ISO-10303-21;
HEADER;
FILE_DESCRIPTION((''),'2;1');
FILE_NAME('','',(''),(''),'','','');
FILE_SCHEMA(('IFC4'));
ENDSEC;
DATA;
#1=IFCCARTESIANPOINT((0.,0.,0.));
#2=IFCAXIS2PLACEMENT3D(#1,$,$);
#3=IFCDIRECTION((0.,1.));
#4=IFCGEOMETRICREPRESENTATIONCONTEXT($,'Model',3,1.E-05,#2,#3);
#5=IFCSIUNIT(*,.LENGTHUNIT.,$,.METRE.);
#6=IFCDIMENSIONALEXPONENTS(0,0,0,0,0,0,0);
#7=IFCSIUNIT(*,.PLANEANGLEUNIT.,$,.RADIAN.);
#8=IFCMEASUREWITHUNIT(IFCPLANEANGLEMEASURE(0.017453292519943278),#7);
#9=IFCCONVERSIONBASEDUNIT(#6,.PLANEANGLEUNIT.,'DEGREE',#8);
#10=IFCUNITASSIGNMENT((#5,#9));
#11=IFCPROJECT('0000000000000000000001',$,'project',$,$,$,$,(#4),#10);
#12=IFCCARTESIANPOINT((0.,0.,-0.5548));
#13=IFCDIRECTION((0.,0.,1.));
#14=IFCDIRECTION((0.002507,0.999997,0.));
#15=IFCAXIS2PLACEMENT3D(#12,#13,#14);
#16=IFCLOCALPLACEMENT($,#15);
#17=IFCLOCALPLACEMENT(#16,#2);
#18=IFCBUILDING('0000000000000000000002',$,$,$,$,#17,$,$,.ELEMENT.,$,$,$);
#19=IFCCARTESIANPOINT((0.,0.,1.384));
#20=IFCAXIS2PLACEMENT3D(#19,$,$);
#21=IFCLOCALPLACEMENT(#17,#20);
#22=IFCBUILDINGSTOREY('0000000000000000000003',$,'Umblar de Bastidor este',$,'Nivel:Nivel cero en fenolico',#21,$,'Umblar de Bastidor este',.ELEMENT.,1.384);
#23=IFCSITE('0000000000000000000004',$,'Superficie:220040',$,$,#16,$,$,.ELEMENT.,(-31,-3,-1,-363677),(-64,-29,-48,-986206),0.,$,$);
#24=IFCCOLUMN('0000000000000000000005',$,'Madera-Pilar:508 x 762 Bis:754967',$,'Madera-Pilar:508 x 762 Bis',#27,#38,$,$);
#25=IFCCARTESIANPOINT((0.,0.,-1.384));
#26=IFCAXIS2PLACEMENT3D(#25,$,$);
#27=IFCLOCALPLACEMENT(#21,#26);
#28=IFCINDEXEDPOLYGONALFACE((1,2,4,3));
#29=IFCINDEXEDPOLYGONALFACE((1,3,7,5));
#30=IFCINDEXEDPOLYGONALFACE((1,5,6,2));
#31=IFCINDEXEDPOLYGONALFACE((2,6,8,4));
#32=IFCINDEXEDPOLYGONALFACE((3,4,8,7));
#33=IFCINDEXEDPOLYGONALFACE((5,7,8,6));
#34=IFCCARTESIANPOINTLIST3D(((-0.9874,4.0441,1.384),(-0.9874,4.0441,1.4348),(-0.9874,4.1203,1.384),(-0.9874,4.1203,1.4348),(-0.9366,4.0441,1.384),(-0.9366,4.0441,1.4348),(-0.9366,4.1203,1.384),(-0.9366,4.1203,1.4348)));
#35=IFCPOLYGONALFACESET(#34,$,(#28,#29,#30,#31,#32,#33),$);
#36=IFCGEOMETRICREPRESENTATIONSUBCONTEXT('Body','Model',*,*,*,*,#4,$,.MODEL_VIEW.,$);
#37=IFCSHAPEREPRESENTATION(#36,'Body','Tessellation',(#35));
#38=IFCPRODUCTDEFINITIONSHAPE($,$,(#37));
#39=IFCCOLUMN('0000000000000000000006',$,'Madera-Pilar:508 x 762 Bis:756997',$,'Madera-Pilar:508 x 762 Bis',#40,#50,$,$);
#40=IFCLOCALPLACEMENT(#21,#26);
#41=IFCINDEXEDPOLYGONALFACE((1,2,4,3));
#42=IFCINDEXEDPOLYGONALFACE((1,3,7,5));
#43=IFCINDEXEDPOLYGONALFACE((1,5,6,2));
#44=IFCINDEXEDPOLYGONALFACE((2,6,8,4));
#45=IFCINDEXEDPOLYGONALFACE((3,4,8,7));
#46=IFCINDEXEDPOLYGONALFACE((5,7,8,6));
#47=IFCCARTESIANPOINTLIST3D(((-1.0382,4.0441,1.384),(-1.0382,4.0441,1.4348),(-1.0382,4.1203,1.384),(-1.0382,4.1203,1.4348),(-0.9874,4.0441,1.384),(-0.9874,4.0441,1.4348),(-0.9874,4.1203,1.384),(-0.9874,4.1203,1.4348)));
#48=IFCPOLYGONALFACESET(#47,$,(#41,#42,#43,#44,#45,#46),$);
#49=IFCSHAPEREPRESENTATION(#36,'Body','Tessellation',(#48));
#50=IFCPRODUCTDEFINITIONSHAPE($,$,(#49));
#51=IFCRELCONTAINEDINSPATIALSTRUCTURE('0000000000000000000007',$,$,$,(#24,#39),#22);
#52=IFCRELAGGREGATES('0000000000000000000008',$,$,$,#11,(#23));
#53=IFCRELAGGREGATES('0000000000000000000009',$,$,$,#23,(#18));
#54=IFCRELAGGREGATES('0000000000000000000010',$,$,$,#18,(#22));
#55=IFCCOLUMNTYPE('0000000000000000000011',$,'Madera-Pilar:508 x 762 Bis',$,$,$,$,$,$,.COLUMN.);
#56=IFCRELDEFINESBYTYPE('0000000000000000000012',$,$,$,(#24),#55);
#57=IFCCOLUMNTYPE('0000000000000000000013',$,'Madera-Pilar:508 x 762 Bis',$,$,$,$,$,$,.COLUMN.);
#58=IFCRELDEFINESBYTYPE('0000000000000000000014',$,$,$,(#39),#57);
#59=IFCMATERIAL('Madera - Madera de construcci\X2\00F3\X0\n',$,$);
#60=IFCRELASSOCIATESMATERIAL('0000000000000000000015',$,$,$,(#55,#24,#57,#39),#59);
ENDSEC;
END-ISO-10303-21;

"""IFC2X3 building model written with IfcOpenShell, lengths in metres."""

from ifc_helpers import new_model, entity, si_unit, converted_unit, direction, frame, frame_2d, origin, place, context, subcontext, project, spatial, rectangle, extrude, source, transform, mapped, material, type_object, type_shapes, element, save


model = new_model("IFC2X3")

# Units and contexts
model_context = context("Model", 3, precision=1e-05, world=origin(), true_north=direction((0.0, 1.0)))
body_context = subcontext(model_context, "Body", "Model", "MODEL_VIEW")
ifc_project = project(units=[si_unit("LENGTHUNIT", "METRE"), converted_unit("PLANEANGLEUNIT", "DEGREE", entity("IfcPlaneAngleMeasure", 0.017453292519943278), si_unit("PLANEANGLEUNIT", "RADIAN"), dimensions=[0, 0, 0, 0, 0, 0, 0])], contexts=[model_context])

# Site, building, storey
site_placement = place(None, frame((0.0, 0.0, -0.5548), z_axis=(0.0, 0.0, 1.0), x_axis=(0.002507, 0.999997, 0.0)))
site = spatial("IfcSite", under=ifc_project, at=site_placement, Name="Superficie:220040", CompositionType="ELEMENT", RefLatitude=(-31, -3, -1, -363677), RefLongitude=(-64, -29, -48, -986206), RefElevation=0.0)
building_placement = place(site_placement, origin())
building = spatial("IfcBuilding", under=site, at=building_placement, CompositionType="ELEMENT")
storey_placement = place(building_placement, frame((0.0, 0.0, 1.384)))
storey = spatial("IfcBuildingStorey", under=building, at=storey_placement, Name="Umblar de Bastidor este", ObjectType="Nivel:Nivel cero en fenolico", LongName="Umblar de Bastidor este", CompositionType="ELEMENT", Elevation=1.384)

# Columns
ifc_material_1 = material(Name="Madera - Madera de construcción")
column_type_1 = type_object("IfcColumnType", Name="Madera-Pilar:508 x 762 Bis", PredefinedType="COLUMN", material=ifc_material_1)
shared_shape_1 = source(origin(), body_context, "Body", "SweptSolid", [
    extrude(rectangle(XDim=0.0508, YDim=0.0762, at=frame_2d((0.0, 0.0), x_axis=(1.0, 0.0))), frame((-0.962, 4.0822, 1.384), z_axis=(0.0, 0.0, 1.0), x_axis=(-1.0, 0.0, 0.0)), (0.0, 0.0, 1.0), 0.0508),
])
type_shapes(column_type_1, [shared_shape_1])
column_1_placement = place(storey_placement, frame((0.0, 0.0, -1.384)))
element("IfcColumn", 1, at=column_1_placement, inside=storey, type_object=column_type_1, material=ifc_material_1, Name="Madera-Pilar:508 x 762 Bis:754967", ObjectType="Madera-Pilar:508 x 762 Bis", context=body_context, shape_type="MappedRepresentation", body=[
    mapped(shared_shape_1, transform((0.0, 0.0, 0.0), scale=1.0)),
])
column_type_2 = type_object("IfcColumnType", Name="Madera-Pilar:508 x 762 Bis", PredefinedType="COLUMN", material=ifc_material_1)
shared_shape_2 = source(origin(), body_context, "Body", "SweptSolid", [
    extrude(rectangle(XDim=0.0508, YDim=0.0762, at=frame_2d((0.0, 0.0), x_axis=(1.0, 0.0))), frame((-1.0128, 4.0822, 1.384), z_axis=(0.0, 0.0, 1.0), x_axis=(-1.0, 0.0, 0.0)), (0.0, 0.0, 1.0), 0.0508),
])
type_shapes(column_type_2, [shared_shape_2])
column_2_placement = place(storey_placement, frame((0.0, 0.0, -1.384)))
element("IfcColumn", 2, at=column_2_placement, inside=storey, type_object=column_type_2, material=ifc_material_1, Name="Madera-Pilar:508 x 762 Bis:756997", ObjectType="Madera-Pilar:508 x 762 Bis", context=body_context, shape_type="MappedRepresentation", body=[
    mapped(shared_shape_2, transform((0.0, 0.0, 0.0), scale=1.0)),
])

save(model, "model.ifc")
